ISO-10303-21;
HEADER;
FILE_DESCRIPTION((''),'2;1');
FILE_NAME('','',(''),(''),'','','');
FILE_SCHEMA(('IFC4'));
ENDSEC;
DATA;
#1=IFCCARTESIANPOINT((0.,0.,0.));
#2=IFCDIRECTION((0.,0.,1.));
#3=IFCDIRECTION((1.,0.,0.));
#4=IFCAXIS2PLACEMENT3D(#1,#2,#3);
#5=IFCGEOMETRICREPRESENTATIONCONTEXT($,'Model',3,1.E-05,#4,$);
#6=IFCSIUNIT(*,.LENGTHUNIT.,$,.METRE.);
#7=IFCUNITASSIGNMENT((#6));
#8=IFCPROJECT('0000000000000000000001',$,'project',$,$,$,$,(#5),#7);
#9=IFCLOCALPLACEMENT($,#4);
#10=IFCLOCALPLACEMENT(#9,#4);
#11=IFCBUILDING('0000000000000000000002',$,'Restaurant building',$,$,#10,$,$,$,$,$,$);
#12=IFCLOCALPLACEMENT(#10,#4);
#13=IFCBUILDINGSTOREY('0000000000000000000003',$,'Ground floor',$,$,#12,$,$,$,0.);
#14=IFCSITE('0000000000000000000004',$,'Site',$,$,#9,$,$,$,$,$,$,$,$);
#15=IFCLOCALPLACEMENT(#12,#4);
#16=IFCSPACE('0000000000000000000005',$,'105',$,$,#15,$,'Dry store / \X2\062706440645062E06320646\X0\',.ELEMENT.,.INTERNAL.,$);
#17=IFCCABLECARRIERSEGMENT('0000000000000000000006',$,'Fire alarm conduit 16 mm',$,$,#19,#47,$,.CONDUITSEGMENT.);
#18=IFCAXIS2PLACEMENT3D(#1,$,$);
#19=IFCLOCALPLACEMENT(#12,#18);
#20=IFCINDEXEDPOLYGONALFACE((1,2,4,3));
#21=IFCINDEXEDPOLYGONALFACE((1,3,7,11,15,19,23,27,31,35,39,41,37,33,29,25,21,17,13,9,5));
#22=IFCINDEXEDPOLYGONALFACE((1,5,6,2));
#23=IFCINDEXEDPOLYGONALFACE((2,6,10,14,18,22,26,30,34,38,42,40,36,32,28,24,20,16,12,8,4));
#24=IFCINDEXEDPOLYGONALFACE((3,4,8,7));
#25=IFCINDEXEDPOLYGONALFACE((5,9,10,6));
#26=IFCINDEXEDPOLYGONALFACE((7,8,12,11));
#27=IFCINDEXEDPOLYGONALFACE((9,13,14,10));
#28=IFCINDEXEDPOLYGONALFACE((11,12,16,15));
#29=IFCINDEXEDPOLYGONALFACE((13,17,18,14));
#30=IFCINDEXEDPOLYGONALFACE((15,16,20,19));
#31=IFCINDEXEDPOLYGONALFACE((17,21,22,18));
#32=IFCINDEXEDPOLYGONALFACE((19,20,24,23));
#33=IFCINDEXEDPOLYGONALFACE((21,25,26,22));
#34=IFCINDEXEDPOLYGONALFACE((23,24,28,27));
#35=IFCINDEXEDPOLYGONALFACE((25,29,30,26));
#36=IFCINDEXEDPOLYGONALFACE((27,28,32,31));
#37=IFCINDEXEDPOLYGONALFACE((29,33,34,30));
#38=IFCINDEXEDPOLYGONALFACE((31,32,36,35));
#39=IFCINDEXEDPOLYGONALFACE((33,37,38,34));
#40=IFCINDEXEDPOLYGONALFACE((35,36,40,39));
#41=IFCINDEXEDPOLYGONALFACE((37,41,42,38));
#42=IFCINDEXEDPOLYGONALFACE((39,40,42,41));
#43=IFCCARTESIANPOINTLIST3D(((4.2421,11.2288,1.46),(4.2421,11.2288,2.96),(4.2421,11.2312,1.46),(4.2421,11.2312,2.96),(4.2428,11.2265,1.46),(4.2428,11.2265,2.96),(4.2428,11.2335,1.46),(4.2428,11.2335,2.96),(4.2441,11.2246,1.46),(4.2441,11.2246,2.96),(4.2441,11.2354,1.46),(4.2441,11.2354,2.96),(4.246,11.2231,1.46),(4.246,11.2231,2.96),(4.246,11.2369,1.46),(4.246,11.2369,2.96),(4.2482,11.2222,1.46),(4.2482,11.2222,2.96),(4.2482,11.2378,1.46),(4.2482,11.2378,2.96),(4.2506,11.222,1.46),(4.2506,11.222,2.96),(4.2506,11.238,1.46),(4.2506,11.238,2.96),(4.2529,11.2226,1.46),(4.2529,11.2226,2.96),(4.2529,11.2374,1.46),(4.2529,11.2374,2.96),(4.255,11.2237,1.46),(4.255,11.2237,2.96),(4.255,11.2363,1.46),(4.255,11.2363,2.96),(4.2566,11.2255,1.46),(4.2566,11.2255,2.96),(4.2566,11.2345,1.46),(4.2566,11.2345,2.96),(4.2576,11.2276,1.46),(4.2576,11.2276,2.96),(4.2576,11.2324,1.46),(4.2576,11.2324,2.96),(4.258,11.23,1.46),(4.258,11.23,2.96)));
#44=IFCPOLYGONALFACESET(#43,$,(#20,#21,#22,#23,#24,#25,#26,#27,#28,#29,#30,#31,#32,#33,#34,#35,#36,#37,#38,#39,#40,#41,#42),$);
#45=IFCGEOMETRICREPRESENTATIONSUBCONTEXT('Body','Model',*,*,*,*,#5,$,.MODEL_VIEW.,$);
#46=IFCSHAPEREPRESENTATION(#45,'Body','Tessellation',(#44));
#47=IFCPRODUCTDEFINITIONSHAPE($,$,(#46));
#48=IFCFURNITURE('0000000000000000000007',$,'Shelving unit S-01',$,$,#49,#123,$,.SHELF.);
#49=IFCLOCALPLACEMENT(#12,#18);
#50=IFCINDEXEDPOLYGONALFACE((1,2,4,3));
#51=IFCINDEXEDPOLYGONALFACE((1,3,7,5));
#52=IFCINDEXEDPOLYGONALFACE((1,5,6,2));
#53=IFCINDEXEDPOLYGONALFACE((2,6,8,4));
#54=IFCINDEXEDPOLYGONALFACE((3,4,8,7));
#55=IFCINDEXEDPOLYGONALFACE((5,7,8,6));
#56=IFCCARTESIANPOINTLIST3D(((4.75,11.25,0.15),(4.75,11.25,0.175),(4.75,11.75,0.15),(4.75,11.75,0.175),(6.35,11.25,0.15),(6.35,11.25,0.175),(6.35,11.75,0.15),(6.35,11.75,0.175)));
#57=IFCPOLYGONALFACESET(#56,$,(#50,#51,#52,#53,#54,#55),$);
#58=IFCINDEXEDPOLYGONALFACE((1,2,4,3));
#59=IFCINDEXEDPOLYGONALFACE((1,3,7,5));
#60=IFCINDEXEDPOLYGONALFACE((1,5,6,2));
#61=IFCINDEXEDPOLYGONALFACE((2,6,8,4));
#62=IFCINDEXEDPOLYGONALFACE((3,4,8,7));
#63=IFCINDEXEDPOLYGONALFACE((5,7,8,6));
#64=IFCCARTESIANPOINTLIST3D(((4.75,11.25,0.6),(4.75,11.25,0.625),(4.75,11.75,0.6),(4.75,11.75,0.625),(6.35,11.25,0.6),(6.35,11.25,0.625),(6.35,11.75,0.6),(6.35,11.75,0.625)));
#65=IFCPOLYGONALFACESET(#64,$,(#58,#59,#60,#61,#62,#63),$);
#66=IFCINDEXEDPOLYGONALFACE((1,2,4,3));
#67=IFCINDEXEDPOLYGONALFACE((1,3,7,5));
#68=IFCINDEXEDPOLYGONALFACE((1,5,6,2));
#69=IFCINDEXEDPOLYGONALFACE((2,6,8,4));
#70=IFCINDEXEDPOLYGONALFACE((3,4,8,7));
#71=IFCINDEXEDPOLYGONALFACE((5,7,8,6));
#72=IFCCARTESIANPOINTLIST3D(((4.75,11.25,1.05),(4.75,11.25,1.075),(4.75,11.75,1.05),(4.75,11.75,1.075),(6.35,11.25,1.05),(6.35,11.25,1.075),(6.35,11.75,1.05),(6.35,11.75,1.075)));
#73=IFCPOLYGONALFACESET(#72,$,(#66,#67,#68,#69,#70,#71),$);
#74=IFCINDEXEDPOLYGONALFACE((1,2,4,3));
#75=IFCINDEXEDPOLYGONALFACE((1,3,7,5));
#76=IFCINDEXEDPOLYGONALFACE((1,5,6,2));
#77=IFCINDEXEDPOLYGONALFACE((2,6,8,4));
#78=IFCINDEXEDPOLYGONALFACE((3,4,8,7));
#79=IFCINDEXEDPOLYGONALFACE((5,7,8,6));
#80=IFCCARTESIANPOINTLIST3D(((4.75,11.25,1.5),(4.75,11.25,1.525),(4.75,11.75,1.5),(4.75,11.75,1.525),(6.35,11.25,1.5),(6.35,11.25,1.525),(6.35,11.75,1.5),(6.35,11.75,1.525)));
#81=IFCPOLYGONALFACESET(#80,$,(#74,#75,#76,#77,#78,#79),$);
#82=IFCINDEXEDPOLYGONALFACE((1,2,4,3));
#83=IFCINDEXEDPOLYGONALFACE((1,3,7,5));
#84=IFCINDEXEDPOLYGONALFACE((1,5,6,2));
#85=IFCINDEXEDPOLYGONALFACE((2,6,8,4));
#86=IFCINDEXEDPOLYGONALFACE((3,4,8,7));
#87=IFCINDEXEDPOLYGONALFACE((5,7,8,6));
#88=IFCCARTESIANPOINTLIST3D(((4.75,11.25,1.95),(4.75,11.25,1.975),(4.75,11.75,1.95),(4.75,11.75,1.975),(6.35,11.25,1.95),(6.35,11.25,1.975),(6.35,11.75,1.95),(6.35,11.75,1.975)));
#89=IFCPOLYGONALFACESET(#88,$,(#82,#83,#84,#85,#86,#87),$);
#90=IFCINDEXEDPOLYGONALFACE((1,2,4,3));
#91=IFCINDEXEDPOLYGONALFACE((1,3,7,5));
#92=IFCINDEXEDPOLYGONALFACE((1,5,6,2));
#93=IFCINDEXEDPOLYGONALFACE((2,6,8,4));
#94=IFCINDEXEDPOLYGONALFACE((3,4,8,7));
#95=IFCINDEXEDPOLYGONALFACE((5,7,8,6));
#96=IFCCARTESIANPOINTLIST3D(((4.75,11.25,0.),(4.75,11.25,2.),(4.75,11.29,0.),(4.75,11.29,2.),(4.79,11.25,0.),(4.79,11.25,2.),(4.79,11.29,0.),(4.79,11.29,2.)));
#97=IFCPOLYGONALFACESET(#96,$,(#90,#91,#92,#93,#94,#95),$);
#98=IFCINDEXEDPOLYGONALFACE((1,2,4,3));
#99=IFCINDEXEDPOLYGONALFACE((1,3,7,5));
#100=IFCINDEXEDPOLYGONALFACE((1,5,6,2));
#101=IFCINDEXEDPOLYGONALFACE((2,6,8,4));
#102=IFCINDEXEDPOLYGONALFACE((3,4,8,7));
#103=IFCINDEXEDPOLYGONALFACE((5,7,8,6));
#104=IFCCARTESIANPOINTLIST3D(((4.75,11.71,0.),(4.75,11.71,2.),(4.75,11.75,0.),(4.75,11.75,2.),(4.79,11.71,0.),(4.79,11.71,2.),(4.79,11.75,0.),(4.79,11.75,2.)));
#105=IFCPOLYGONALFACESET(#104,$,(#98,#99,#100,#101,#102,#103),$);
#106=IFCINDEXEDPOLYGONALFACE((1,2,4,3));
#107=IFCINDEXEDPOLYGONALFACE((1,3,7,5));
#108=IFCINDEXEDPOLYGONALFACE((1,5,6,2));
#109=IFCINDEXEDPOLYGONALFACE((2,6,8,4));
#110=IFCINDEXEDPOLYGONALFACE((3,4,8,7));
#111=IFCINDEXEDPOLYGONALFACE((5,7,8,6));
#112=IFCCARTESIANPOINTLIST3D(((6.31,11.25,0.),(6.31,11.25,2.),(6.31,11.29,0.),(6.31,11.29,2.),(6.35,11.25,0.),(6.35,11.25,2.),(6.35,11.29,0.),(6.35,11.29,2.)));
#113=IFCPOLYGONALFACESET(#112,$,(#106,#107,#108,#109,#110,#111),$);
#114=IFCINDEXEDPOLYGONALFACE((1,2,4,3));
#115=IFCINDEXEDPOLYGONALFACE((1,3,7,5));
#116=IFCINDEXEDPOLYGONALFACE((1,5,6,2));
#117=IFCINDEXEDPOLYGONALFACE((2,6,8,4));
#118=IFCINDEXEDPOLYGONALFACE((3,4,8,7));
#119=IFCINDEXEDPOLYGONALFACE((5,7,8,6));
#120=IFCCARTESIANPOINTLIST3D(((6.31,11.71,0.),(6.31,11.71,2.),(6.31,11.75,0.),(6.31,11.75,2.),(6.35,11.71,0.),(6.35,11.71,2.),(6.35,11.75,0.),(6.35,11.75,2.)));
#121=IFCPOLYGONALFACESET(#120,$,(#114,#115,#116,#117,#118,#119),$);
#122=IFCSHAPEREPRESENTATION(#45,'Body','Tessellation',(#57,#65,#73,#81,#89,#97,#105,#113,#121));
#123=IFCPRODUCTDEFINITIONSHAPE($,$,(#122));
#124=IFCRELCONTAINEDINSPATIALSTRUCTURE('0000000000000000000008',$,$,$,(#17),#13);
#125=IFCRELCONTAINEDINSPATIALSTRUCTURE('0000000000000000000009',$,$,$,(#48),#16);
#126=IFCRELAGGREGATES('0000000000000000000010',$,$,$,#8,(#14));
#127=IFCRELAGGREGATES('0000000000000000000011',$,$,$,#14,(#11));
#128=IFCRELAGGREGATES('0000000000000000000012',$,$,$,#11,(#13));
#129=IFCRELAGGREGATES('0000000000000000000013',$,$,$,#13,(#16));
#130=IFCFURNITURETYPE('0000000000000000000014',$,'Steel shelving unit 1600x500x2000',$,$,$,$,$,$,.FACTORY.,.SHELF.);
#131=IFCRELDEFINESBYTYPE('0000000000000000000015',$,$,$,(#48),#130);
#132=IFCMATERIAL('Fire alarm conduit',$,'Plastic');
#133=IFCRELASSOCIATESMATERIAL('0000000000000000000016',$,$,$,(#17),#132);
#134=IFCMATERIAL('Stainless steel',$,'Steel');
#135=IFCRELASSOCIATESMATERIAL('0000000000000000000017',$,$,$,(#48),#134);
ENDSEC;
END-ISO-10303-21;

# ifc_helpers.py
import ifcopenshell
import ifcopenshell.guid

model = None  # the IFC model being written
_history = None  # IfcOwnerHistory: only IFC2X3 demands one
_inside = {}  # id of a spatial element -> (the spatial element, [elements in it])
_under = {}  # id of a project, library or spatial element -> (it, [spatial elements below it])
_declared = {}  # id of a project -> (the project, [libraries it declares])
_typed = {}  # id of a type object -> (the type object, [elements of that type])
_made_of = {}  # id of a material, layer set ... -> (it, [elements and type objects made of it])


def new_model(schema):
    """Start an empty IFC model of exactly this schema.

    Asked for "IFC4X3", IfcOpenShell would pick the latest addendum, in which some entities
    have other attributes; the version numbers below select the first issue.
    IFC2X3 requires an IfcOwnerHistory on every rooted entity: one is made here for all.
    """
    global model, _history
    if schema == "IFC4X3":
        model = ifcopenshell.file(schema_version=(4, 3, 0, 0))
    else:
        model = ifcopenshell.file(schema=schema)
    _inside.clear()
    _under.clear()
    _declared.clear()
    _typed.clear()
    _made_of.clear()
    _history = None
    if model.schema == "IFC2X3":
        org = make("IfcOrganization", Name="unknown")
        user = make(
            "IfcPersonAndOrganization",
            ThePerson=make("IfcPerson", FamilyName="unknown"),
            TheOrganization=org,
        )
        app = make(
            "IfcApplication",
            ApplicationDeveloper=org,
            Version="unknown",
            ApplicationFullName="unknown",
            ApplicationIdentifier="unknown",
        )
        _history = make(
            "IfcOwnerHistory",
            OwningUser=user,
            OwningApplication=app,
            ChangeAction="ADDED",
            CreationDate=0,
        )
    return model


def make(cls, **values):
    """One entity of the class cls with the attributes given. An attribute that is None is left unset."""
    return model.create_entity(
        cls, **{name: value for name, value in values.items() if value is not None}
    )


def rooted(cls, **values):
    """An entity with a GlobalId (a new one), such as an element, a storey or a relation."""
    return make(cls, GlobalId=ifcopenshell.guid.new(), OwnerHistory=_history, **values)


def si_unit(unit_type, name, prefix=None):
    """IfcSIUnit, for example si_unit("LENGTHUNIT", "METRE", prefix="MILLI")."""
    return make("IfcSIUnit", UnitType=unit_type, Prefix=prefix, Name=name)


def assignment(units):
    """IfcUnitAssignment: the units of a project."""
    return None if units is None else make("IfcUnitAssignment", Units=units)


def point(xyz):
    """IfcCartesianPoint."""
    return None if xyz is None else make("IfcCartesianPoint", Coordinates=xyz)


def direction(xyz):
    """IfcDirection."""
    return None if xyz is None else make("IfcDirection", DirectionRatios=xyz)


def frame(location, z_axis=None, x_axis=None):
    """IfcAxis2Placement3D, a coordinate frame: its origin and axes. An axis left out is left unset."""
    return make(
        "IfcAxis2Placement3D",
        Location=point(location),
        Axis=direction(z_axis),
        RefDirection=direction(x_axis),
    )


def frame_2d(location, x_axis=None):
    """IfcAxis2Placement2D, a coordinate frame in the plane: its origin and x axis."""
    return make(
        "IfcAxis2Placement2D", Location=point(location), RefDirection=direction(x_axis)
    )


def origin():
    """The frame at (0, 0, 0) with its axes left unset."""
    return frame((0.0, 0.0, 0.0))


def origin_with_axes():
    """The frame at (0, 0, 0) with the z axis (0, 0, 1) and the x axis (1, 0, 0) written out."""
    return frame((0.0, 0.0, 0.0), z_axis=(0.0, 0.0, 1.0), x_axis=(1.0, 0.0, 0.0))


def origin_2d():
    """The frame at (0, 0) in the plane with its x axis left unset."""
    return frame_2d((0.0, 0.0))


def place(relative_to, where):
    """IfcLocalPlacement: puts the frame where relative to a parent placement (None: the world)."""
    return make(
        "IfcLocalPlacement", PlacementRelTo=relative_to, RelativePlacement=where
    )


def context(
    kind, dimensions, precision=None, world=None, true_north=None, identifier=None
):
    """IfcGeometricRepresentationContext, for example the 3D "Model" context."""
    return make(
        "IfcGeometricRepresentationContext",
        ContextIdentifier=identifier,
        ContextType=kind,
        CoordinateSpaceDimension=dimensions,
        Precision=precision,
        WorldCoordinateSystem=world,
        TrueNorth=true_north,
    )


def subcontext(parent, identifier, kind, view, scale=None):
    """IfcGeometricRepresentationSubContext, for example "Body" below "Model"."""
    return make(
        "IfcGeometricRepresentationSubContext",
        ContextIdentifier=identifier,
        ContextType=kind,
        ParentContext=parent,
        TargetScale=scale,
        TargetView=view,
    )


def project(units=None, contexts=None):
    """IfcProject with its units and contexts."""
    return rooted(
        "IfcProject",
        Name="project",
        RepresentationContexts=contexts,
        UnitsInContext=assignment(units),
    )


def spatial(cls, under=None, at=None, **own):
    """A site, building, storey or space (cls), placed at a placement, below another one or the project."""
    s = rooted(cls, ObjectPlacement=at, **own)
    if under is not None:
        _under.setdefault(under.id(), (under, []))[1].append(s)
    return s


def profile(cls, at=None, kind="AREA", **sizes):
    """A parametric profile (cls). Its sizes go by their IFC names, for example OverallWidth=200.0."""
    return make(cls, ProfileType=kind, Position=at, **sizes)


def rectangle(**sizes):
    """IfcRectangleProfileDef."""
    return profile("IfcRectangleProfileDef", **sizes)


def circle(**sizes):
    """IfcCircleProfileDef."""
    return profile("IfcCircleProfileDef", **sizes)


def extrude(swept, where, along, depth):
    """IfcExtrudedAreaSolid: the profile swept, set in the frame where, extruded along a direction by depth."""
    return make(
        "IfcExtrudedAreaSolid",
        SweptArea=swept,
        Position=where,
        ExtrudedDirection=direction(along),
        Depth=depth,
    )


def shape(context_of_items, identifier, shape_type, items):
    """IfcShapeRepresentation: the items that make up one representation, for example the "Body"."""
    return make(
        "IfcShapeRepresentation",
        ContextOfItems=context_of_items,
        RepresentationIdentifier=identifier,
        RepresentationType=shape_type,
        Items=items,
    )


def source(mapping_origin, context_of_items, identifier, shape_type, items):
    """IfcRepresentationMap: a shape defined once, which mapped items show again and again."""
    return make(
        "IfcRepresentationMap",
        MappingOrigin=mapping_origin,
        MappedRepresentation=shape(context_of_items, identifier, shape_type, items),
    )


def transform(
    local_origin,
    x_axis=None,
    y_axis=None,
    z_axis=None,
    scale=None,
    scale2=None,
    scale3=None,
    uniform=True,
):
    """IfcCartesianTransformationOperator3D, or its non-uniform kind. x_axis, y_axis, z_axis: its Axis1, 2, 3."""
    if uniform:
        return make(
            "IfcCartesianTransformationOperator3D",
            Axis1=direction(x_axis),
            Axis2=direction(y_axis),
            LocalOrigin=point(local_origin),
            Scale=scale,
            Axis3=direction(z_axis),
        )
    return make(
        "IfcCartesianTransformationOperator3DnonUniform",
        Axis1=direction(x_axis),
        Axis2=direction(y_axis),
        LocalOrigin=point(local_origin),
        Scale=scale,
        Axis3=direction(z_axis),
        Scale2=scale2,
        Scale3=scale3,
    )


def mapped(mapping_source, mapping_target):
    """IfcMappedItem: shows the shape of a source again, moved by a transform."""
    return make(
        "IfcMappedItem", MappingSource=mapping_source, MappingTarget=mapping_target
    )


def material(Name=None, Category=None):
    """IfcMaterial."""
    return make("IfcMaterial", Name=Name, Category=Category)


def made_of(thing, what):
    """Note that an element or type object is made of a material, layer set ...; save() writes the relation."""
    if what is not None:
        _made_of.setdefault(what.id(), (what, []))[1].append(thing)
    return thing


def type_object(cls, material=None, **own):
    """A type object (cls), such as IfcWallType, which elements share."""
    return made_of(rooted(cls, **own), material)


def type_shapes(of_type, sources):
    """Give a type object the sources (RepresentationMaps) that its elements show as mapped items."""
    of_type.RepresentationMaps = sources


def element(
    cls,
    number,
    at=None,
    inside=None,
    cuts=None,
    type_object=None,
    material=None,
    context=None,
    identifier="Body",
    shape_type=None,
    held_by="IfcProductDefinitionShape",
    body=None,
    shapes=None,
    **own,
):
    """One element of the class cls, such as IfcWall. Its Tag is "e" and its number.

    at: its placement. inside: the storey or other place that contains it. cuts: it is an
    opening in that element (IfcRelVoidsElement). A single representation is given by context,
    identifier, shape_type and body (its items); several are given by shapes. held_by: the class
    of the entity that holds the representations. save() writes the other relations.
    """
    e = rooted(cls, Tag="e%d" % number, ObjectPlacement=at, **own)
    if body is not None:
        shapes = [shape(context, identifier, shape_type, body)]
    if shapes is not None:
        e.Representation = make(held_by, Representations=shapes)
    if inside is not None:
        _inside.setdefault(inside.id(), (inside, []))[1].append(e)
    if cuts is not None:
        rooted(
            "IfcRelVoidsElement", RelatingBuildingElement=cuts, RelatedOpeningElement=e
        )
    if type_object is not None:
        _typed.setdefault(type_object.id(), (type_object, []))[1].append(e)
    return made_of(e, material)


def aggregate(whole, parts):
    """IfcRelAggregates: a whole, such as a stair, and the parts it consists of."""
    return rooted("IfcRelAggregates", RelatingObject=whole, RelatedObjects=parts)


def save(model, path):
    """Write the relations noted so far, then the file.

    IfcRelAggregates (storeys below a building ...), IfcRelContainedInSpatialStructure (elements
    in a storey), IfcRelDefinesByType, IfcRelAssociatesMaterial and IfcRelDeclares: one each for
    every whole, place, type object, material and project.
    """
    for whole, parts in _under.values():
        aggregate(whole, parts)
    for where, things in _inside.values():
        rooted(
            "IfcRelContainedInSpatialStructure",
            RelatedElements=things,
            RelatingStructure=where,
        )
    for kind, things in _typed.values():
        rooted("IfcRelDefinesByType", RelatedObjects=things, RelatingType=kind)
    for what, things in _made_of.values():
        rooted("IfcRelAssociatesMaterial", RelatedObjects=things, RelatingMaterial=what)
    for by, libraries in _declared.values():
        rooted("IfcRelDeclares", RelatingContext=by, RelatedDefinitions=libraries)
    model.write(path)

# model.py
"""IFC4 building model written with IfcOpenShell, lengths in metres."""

from ifc_helpers import new_model, si_unit, frame, origin, origin_with_axes, origin_2d, place, context, subcontext, project, spatial, rectangle, circle, extrude, source, transform, mapped, material, type_object, type_shapes, element, save


model = new_model("IFC4")

# Units and contexts
model_context = context("Model", 3, precision=1e-05, world=origin_with_axes())
body_context = subcontext(model_context, "Body", "Model", "MODEL_VIEW")
ifc_project = project(units=[si_unit("LENGTHUNIT", "METRE")], contexts=[model_context])

# Site, building, storey, space
site_placement = place(None, origin_with_axes())
site = spatial("IfcSite", under=ifc_project, at=site_placement, Name="Site")
building_placement = place(site_placement, origin_with_axes())
building = spatial("IfcBuilding", under=site, at=building_placement, Name="Restaurant building")
storey_placement = place(building_placement, origin_with_axes())
storey = spatial("IfcBuildingStorey", under=building, at=storey_placement, Name="Ground floor", Elevation=0.0)
space_1_placement = place(storey_placement, origin_with_axes())
space_1 = spatial("IfcSpace", under=storey, at=space_1_placement, Name="105", LongName="Dry store / المخزن", CompositionType="ELEMENT", PredefinedType="INTERNAL")

# Cable carrier segment
ifc_material_1 = material(Name="Fire alarm conduit", Category="Plastic")
cable_carrier_segment_1_placement = place(storey_placement, frame((4.25, 11.23, 1.46)))
element("IfcCableCarrierSegment", 1, at=cable_carrier_segment_1_placement, inside=storey, material=ifc_material_1, Name="Fire alarm conduit 16 mm", PredefinedType="CONDUITSEGMENT", context=body_context, shape_type="SweptSolid", body=[
    extrude(circle(Radius=0.008, at=origin_2d()), origin(), (0.0, 0.0, 1.0), 1.5),
])

# Furniture
ifc_material_2 = material(Name="Stainless steel", Category="Steel")
furniture_type = type_object("IfcFurnitureType", Name="Steel shelving unit 1600x500x2000", AssemblyPlace="FACTORY", PredefinedType="SHELF")
shared_shape_1 = source(origin(), body_context, "Body", "SweptSolid", [
    extrude(rectangle(XDim=1.6, YDim=0.5, at=origin_2d()), frame((0.0, 0.0, 0.15)), (0.0, 0.0, 1.0), 0.025),
    extrude(rectangle(XDim=1.6, YDim=0.5, at=origin_2d()), frame((0.0, 0.0, 0.6)), (0.0, 0.0, 1.0), 0.025),
    extrude(rectangle(XDim=1.6, YDim=0.5, at=origin_2d()), frame((0.0, 0.0, 1.05)), (0.0, 0.0, 1.0), 0.025),
    extrude(rectangle(XDim=1.6, YDim=0.5, at=origin_2d()), frame((0.0, 0.0, 1.5)), (0.0, 0.0, 1.0), 0.025),
    extrude(rectangle(XDim=1.6, YDim=0.5, at=origin_2d()), frame((0.0, 0.0, 1.95)), (0.0, 0.0, 1.0), 0.025),
    extrude(rectangle(XDim=0.04, YDim=0.04, at=origin_2d()), frame((-0.78, -0.23, 0.0)), (0.0, 0.0, 1.0), 2.0),
    extrude(rectangle(XDim=0.04, YDim=0.04, at=origin_2d()), frame((-0.78, 0.23, 0.0)), (0.0, 0.0, 1.0), 2.0),
    extrude(rectangle(XDim=0.04, YDim=0.04, at=origin_2d()), frame((0.78, -0.23, 0.0)), (0.0, 0.0, 1.0), 2.0),
    extrude(rectangle(XDim=0.04, YDim=0.04, at=origin_2d()), frame((0.78, 0.23, 0.0)), (0.0, 0.0, 1.0), 2.0),
])
type_shapes(furniture_type, [shared_shape_1])
furniture_placement = place(storey_placement, frame((5.55, 11.5, 0.0)))
element("IfcFurniture", 2, at=furniture_placement, inside=space_1, type_object=furniture_type, material=ifc_material_2, Name="Shelving unit S-01", PredefinedType="SHELF", context=body_context, shape_type="MappedRepresentation", body=[
    mapped(shared_shape_1, transform((0.0, 0.0, 0.0))),
])

save(model, "model.ifc")
